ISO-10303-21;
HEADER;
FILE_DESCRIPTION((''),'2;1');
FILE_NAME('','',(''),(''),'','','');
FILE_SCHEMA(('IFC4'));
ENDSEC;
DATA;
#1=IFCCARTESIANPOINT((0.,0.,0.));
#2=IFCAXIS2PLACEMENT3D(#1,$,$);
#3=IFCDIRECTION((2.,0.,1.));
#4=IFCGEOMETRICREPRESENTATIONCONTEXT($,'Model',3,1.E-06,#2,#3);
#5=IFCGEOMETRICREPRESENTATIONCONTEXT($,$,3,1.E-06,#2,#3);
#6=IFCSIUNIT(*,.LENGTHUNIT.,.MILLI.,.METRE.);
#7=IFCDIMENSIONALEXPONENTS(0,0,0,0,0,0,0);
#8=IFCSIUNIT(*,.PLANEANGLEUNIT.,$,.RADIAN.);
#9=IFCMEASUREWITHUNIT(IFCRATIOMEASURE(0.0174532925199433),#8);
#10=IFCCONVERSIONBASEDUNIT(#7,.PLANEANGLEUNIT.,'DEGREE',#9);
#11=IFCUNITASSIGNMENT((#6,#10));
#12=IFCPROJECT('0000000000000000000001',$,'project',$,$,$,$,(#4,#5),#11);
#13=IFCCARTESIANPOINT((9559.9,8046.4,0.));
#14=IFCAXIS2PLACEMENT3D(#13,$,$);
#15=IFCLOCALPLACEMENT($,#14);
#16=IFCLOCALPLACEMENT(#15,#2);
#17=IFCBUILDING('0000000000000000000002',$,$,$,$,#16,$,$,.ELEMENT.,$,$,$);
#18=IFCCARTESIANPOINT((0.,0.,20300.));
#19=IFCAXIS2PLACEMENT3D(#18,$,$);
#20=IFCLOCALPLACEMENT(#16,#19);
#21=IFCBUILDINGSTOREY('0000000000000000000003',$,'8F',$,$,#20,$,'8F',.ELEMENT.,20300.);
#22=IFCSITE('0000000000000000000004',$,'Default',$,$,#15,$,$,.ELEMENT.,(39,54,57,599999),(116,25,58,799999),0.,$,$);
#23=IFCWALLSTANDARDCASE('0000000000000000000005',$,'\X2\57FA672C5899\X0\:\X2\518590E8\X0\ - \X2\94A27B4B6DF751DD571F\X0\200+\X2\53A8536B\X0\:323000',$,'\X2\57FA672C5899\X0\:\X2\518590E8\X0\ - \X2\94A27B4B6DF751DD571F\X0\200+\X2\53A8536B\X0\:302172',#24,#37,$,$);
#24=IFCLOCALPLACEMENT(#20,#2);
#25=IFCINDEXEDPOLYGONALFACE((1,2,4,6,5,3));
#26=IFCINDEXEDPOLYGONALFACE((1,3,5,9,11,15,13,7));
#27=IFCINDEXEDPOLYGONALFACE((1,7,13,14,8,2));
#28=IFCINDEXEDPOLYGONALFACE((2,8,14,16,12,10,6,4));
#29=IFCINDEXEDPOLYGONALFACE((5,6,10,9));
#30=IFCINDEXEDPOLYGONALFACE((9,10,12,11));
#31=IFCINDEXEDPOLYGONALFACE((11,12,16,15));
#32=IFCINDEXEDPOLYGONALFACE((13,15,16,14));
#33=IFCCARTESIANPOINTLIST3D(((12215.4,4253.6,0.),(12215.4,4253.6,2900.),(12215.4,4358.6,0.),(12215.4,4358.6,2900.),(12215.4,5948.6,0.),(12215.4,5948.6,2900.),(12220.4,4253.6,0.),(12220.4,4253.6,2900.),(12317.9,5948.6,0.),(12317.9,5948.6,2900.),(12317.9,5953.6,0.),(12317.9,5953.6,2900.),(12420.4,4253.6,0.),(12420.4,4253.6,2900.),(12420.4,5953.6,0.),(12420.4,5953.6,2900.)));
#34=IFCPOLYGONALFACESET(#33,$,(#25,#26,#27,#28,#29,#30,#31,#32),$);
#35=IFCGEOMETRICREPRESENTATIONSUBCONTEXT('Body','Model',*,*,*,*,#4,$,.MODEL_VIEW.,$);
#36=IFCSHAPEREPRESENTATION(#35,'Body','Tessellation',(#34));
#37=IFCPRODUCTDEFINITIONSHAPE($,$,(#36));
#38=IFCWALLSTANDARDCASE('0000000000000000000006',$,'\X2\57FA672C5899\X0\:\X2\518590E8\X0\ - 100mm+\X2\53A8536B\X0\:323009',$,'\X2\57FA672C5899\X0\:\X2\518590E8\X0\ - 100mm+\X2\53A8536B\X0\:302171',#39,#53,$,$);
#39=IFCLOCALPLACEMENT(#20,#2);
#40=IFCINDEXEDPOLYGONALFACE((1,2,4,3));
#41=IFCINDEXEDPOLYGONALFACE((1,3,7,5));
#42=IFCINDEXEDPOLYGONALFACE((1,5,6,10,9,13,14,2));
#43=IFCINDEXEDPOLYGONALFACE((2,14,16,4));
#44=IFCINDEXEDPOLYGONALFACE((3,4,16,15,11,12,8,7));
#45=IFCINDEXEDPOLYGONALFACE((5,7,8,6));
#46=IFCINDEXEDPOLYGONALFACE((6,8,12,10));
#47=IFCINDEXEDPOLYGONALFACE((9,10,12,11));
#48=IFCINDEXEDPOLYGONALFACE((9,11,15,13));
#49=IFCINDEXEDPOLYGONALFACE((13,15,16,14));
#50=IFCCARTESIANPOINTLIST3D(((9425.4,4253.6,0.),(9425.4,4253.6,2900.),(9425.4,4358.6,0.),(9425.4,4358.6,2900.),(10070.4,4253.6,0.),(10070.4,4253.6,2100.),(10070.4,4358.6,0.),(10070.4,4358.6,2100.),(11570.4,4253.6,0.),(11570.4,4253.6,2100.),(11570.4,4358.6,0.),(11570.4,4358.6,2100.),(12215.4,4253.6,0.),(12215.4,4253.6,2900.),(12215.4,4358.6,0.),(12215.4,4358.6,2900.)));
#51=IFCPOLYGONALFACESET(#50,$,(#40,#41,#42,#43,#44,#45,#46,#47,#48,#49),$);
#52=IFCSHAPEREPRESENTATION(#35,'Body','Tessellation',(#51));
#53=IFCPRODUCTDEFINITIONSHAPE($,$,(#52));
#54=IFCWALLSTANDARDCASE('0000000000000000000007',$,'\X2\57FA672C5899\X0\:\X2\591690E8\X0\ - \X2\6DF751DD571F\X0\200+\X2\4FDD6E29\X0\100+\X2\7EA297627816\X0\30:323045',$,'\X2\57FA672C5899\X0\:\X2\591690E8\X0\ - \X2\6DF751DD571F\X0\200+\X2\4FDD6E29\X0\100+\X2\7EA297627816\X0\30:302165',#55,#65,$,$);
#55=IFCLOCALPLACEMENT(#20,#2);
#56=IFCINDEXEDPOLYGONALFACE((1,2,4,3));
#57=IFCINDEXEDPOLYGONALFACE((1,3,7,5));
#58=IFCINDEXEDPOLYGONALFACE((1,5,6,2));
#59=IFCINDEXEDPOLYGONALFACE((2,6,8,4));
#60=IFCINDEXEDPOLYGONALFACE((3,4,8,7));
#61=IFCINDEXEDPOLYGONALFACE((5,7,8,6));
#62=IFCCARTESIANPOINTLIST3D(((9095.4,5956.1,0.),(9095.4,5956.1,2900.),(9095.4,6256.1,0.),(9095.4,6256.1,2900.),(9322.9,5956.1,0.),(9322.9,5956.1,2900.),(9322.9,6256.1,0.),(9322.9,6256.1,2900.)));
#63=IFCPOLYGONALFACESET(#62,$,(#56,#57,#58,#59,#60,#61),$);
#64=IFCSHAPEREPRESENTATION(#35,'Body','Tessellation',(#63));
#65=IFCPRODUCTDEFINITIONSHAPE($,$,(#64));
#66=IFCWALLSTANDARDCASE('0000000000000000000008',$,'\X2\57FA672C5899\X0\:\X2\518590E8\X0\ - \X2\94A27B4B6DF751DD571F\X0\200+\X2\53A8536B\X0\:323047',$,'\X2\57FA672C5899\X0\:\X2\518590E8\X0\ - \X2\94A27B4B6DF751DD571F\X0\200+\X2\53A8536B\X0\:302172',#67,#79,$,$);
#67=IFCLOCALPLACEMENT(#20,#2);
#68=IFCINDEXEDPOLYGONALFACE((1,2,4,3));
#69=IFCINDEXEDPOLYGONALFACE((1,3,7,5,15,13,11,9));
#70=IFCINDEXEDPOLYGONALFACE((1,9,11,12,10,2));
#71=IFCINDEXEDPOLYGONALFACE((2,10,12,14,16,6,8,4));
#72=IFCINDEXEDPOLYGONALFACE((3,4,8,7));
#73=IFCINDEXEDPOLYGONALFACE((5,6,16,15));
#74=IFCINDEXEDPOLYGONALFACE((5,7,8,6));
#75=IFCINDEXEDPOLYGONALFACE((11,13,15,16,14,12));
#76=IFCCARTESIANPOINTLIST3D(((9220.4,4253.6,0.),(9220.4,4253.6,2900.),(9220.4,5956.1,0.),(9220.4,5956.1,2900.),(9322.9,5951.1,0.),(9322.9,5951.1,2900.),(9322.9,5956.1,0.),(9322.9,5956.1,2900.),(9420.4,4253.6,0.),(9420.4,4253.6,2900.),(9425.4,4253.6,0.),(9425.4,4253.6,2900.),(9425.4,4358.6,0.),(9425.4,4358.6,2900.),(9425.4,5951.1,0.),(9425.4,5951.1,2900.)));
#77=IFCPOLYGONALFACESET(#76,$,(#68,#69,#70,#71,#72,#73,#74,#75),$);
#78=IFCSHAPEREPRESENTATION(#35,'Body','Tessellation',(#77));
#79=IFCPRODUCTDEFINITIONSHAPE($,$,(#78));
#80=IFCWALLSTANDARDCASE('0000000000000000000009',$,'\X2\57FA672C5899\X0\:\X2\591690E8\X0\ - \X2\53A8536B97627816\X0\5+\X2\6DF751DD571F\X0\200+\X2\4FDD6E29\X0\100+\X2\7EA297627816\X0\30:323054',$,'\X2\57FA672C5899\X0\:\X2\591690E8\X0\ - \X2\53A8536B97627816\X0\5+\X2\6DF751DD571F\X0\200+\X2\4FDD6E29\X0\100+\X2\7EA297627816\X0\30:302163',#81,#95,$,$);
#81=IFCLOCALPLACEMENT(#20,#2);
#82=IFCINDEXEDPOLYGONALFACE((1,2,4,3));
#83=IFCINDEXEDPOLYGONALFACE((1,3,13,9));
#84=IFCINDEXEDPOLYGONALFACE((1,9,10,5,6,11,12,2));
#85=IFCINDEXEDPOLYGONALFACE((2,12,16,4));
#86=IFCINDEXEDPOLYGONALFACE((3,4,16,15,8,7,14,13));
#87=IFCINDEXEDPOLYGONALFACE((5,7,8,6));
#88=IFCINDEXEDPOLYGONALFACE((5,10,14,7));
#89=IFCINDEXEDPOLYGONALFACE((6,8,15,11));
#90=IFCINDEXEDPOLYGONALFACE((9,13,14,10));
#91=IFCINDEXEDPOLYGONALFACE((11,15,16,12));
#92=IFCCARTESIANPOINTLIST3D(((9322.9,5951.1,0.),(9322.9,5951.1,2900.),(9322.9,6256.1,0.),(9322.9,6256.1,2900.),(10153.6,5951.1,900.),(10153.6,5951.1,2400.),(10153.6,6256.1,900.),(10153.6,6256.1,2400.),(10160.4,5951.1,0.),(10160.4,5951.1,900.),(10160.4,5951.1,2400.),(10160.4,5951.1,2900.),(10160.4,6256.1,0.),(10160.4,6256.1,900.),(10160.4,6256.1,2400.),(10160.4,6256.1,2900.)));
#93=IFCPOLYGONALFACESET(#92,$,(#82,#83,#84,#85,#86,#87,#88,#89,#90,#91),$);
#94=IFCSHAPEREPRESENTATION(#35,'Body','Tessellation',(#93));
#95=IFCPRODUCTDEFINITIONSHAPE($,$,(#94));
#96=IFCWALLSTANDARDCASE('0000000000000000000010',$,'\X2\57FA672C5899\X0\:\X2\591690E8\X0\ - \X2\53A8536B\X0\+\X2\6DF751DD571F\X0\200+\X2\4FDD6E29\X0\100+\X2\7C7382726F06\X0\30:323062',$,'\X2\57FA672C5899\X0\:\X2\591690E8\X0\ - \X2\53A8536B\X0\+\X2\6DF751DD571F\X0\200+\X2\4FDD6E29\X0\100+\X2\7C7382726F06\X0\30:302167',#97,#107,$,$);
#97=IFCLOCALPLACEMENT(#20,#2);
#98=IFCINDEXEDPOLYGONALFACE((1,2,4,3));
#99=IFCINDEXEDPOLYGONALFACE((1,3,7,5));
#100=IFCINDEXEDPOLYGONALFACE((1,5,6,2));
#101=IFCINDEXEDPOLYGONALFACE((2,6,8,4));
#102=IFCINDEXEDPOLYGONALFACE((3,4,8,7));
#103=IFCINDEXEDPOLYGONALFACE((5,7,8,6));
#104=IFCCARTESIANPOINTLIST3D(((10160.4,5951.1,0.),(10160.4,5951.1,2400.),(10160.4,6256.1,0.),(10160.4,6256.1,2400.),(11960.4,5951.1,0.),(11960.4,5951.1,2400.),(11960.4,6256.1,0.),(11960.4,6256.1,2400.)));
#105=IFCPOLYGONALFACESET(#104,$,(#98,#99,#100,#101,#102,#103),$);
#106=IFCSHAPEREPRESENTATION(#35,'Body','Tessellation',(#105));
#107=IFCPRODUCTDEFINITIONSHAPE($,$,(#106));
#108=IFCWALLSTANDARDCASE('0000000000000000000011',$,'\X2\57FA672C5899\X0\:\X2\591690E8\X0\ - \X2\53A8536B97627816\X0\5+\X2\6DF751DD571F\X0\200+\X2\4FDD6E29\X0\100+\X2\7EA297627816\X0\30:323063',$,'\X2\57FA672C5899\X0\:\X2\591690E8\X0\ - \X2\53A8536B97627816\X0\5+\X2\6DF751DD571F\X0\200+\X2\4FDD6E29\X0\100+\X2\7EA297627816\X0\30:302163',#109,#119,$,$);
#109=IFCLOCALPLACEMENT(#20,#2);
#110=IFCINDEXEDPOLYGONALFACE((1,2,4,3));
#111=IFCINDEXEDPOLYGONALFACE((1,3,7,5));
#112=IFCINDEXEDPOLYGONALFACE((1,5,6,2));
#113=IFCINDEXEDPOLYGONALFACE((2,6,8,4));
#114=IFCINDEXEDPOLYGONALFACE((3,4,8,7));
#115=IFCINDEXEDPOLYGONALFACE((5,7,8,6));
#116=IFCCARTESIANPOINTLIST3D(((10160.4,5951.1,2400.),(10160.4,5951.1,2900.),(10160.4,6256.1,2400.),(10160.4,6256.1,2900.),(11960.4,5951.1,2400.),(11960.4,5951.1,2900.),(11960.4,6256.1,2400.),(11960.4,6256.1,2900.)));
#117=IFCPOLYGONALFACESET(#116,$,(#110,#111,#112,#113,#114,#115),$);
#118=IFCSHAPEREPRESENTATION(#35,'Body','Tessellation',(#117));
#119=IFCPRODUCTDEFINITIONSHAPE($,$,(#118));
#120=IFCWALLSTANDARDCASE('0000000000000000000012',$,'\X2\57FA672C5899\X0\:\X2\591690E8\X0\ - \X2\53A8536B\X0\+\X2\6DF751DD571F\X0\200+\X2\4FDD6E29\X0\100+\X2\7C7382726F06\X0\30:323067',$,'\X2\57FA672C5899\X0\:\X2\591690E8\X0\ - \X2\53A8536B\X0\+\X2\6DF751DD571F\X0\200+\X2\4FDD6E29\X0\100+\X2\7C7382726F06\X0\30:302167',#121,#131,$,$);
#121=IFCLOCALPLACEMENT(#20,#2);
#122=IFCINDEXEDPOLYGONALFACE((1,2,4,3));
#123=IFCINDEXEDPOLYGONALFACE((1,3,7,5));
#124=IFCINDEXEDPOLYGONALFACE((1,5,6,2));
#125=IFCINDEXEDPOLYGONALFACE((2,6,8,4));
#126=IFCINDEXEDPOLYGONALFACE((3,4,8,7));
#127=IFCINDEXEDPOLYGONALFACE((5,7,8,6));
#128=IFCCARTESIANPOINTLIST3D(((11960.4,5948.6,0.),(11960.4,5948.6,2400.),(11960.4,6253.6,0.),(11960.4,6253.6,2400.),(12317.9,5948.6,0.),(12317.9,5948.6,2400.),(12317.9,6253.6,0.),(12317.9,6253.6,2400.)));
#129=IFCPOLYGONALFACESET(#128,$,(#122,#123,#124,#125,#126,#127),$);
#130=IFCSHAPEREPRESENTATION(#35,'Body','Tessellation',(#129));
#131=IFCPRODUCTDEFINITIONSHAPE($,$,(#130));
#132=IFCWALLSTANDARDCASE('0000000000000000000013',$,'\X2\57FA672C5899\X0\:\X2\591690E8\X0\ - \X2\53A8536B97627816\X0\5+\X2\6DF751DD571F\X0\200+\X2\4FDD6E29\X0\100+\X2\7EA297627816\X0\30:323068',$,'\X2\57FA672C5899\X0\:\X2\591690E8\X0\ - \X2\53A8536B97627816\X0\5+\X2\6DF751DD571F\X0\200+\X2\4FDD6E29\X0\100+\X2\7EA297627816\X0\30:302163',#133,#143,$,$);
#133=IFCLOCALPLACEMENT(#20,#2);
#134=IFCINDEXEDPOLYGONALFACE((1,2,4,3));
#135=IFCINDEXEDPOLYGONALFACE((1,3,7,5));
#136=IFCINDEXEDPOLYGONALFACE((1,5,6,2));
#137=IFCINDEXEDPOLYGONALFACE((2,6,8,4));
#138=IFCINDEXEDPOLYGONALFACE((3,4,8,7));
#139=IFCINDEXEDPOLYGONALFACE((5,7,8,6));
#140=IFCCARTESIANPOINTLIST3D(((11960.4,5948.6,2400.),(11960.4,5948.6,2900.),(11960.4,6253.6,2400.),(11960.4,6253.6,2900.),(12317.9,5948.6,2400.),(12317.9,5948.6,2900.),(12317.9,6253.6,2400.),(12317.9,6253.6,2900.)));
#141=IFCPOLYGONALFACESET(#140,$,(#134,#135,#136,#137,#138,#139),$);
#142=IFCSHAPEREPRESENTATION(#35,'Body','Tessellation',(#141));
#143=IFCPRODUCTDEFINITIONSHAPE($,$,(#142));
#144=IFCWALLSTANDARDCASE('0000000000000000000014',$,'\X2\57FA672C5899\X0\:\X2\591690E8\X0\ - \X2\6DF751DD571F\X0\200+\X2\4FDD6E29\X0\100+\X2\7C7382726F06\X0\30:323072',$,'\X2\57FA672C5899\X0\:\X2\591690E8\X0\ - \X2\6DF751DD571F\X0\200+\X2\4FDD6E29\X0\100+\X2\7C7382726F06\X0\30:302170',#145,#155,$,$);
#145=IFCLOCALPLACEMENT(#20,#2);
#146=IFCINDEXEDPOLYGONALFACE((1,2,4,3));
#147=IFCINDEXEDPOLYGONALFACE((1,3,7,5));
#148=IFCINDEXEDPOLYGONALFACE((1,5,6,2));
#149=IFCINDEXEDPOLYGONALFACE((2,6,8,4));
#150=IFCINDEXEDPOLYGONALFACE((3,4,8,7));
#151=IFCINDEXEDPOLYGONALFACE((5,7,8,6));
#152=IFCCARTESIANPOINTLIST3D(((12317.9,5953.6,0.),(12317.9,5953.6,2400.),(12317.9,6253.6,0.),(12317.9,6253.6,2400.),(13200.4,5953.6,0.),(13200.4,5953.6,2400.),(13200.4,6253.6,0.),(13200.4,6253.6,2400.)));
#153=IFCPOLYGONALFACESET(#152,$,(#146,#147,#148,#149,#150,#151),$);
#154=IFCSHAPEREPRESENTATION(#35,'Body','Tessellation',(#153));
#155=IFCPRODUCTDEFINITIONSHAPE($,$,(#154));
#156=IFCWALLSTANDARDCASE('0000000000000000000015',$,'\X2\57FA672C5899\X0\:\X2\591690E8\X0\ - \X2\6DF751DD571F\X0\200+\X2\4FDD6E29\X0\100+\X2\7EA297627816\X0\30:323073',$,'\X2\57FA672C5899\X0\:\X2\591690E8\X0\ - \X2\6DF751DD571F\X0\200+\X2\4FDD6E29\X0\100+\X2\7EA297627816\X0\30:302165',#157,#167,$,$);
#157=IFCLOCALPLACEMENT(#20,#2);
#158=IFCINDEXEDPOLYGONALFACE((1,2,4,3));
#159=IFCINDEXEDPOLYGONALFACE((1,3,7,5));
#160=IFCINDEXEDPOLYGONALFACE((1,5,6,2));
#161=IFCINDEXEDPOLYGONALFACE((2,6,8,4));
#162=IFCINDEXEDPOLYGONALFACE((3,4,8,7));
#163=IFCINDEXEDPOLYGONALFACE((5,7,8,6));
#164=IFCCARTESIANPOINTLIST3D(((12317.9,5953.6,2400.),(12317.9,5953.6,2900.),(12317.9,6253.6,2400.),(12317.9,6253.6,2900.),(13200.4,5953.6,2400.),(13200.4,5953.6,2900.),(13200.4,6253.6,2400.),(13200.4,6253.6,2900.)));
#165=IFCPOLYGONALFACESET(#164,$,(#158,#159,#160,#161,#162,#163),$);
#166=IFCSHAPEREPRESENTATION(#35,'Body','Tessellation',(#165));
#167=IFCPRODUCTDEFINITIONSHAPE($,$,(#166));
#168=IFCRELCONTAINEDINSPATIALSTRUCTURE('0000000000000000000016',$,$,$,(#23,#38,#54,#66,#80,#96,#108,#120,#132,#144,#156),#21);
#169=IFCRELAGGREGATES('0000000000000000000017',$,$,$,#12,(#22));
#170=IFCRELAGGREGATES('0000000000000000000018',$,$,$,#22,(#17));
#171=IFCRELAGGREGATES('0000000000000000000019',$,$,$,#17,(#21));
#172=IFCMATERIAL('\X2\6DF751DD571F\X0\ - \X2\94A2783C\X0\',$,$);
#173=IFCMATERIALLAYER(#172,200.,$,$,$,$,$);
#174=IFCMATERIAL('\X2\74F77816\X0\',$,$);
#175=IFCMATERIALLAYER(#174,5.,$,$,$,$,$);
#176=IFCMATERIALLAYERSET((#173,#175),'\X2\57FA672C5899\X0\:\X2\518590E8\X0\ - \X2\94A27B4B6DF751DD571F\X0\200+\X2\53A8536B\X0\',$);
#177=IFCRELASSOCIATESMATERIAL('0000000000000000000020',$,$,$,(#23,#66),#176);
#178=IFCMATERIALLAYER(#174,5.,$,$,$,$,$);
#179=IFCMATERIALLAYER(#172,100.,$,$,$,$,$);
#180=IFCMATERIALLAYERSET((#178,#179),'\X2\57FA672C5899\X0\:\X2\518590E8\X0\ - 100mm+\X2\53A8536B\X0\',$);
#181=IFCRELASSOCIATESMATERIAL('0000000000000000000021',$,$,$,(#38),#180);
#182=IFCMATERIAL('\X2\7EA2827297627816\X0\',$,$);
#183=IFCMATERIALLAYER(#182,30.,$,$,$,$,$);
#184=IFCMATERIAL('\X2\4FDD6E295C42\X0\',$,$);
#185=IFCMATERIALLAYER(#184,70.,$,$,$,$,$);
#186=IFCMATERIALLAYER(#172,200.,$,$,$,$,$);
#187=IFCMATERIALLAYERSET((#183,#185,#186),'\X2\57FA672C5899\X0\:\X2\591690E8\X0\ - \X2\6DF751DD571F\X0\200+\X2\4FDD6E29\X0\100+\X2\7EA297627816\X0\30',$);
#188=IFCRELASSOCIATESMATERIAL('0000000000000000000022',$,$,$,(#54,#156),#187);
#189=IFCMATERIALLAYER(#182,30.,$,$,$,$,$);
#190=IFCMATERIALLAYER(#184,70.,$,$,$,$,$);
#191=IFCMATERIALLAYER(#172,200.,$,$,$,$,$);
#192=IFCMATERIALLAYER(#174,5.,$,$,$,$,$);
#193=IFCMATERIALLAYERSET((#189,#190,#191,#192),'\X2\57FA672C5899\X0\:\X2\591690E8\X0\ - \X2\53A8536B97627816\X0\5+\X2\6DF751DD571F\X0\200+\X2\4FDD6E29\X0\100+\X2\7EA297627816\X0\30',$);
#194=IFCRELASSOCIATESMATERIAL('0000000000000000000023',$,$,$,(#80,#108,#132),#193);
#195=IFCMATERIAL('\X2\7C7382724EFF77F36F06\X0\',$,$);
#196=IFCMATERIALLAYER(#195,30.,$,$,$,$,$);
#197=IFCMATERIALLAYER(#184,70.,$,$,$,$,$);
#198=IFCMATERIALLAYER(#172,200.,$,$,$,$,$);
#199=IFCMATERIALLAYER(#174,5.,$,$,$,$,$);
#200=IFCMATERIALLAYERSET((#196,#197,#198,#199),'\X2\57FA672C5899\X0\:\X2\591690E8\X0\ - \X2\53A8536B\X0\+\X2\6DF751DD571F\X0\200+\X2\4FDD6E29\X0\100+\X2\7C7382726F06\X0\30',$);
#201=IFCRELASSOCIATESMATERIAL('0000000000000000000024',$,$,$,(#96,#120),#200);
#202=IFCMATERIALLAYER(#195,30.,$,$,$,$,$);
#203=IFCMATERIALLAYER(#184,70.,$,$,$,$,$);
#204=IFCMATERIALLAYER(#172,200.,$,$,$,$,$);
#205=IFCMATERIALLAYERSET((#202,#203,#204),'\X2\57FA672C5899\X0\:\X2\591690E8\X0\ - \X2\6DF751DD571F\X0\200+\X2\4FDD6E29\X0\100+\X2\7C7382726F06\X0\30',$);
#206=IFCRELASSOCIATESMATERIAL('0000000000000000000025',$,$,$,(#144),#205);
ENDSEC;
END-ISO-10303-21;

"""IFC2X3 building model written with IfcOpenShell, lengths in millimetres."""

from ifc_helpers import new_model, entity, si_unit, converted_unit, direction, frame, frame_2d, origin, place, context, subcontext, project, spatial, polyline, rectangle, outline, extrude, material, layer, layer_set, layer_usage, element, save


model = new_model("IFC2X3")

# Units and contexts
model_context = context("Model", 3, precision=1e-06, world=origin(), true_north=direction((2.0, 0.0, 1.0)))
context_of_model = context(None, 3, precision=1e-06, world=origin(), true_north=direction((2.0, 0.0, 1.0)))
body_context = subcontext(model_context, "Body", "Model", "MODEL_VIEW")
ifc_project = project(units=[si_unit("LENGTHUNIT", "METRE", prefix="MILLI"), converted_unit("PLANEANGLEUNIT", "DEGREE", entity("IfcRatioMeasure", 0.0174532925199433), si_unit("PLANEANGLEUNIT", "RADIAN"), dimensions=[0, 0, 0, 0, 0, 0, 0])], contexts=[model_context, context_of_model])

# Site, building, storey
site_placement = place(None, frame((9559.9, 8046.4, 0.0)))
site = spatial("IfcSite", under=ifc_project, at=site_placement, Name="Default", CompositionType="ELEMENT", RefLatitude=(39, 54, 57, 599999), RefLongitude=(116, 25, 58, 799999), RefElevation=0.0)
building_placement = place(site_placement, origin())
building = spatial("IfcBuilding", under=site, at=building_placement, CompositionType="ELEMENT")
storey_placement = place(building_placement, frame((0.0, 0.0, 20300.0)))
storey = spatial("IfcBuildingStorey", under=building, at=storey_placement, Name="8F", LongName="8F", CompositionType="ELEMENT", Elevation=20300.0)

# Shared definitions
ifc_material_1 = material(Name="红色面砖")
ifc_layer_1 = layer(ifc_material_1, 30.0)
ifc_material_2 = material(Name="保温层")
ifc_layer_2 = layer(ifc_material_2, 70.0)
ifc_material_3 = material(Name="混凝土 - 钢砼")
ifc_layer_3 = layer(ifc_material_3, 200.0)
ifc_layer_set_1 = layer_set([ifc_layer_1, ifc_layer_2, ifc_layer_3], Name="基本墙:外部 - 混凝土200+保温100+红面砖30")

# Wall
ifc_layer_4 = layer(ifc_material_3, 200.0)
ifc_material_4 = material(Name="瓷砖")
ifc_layer_5 = layer(ifc_material_4, 5.0)
ifc_layer_set_2 = layer_set([ifc_layer_4, ifc_layer_5], Name="基本墙:内部 - 钢筋混凝土200+厨卫")
ifc_layer_usage_1 = layer_usage(ifc_layer_set_2, "AXIS2", "NEGATIVE", 102.5)
wall_1_placement = place(storey_placement, frame((12317.9, 5953.6, 0.0), z_axis=(0.0, 0.0, 1.0), x_axis=(0.0, -1.0, 0.0)))
element("IfcWallStandardCase", 1, at=wall_1_placement, inside=storey, material=ifc_layer_usage_1, Name="基本墙:内部 - 钢筋混凝土200+厨卫:323000", ObjectType="基本墙:内部 - 钢筋混凝土200+厨卫:302172", context=body_context, shape_type="SweptSolid", body=[
    extrude(outline(polyline([(1700.0, -102.5), (1700.0, -97.5), (1700.0, 102.5), (0.0, 102.5), (0.0, 0.0), (5.0, 0.0), (5.0, -102.5), (1595.0, -102.5), (1700.0, -102.5)])), origin(), (0.0, 0.0, 1.0), 2900.0),
])

# Wall, opening
ifc_layer_6 = layer(ifc_material_4, 5.0)
ifc_layer_7 = layer(ifc_material_3, 100.0)
ifc_layer_set_3 = layer_set([ifc_layer_6, ifc_layer_7], Name="基本墙:内部 - 100mm+厨卫")
ifc_layer_usage_2 = layer_usage(ifc_layer_set_3, "AXIS2", "POSITIVE", -52.5)
wall_2_placement = place(storey_placement, frame((12215.4, 4306.1, 0.0), z_axis=(0.0, 0.0, 1.0), x_axis=(-1.0, 0.0, 0.0)))
wall_2 = element("IfcWallStandardCase", 2, at=wall_2_placement, inside=storey, material=ifc_layer_usage_2, Name="基本墙:内部 - 100mm+厨卫:323009", ObjectType="基本墙:内部 - 100mm+厨卫:302171", context=body_context, shape_type="SweptSolid", body=[
    extrude(rectangle(XDim=2790.0, YDim=105.0, at=frame_2d((1395.0, 0.0), x_axis=(-1.0, 0.0))), origin(), (0.0, 0.0, 1.0), 2900.0),
])
opening_1_placement = place(wall_2_placement, frame((645.0, -52.5, 0.0)))
element("IfcOpeningElement", 3, at=opening_1_placement, cuts=wall_2, ObjectType="Opening", context=body_context, shape_type="SweptSolid", body=[
    extrude(rectangle(XDim=2100.0, YDim=1500.0, at=frame_2d((1050.0, 750.0), x_axis=(1.0, 0.0))), frame((0.0, 0.0, 0.0), z_axis=(0.0, 1.0, 0.0), x_axis=(0.0, 0.0, 1.0)), (0.0, 0.0, 1.0), 105.0),
])

# Walls
ifc_layer_usage_3 = layer_usage(ifc_layer_set_1, "AXIS2", "POSITIVE", -150.0)
wall_3_placement = place(storey_placement, frame((9322.9, 6106.1, 0.0), z_axis=(0.0, 0.0, 1.0), x_axis=(-1.0, 0.0, 0.0)))
element("IfcWallStandardCase", 4, at=wall_3_placement, inside=storey, material=ifc_layer_usage_3, Name="基本墙:外部 - 混凝土200+保温100+红面砖30:323045", ObjectType="基本墙:外部 - 混凝土200+保温100+红面砖30:302165", context=body_context, shape_type="SweptSolid", body=[
    extrude(rectangle(XDim=227.5, YDim=300.0, at=frame_2d((113.8, 0.0), x_axis=(-1.0, 0.0))), origin(), (0.0, 0.0, 1.0), 2900.0),
])
ifc_layer_usage_4 = layer_usage(ifc_layer_set_2, "AXIS2", "POSITIVE", -102.5)
wall_4_placement = place(storey_placement, frame((9322.9, 5956.1, 0.0), z_axis=(0.0, 0.0, 1.0), x_axis=(0.0, -1.0, 0.0)))
element("IfcWallStandardCase", 5, at=wall_4_placement, inside=storey, material=ifc_layer_usage_4, Name="基本墙:内部 - 钢筋混凝土200+厨卫:323047", ObjectType="基本墙:内部 - 钢筋混凝土200+厨卫:302172", context=body_context, shape_type="SweptSolid", body=[
    extrude(outline(polyline([(1702.5, -102.5), (1702.5, 97.5), (1702.5, 102.5), (1597.5, 102.5), (5.0, 102.5), (5.0, 0.0), (0.0, 0.0), (0.0, -102.5), (1702.5, -102.5)])), origin(), (0.0, 0.0, 1.0), 2900.0),
])

# Wall, opening
ifc_layer_8 = layer(ifc_material_1, 30.0)
ifc_layer_9 = layer(ifc_material_2, 70.0)
ifc_layer_10 = layer(ifc_material_3, 200.0)
ifc_layer_11 = layer(ifc_material_4, 5.0)
ifc_layer_set_4 = layer_set([ifc_layer_8, ifc_layer_9, ifc_layer_10, ifc_layer_11], Name="基本墙:外部 - 厨卫面砖5+混凝土200+保温100+红面砖30")
ifc_layer_usage_5 = layer_usage(ifc_layer_set_4, "AXIS2", "POSITIVE", -152.5)
wall_5_placement = place(storey_placement, frame((10160.4, 6103.6, 0.0), z_axis=(0.0, 0.0, 1.0), x_axis=(-1.0, 0.0, 0.0)))
wall_5 = element("IfcWallStandardCase", 6, at=wall_5_placement, inside=storey, material=ifc_layer_usage_5, Name="基本墙:外部 - 厨卫面砖5+混凝土200+保温100+红面砖30:323054", ObjectType="基本墙:外部 - 厨卫面砖5+混凝土200+保温100+红面砖30:302163", context=body_context, shape_type="SweptSolid", body=[
    extrude(rectangle(XDim=837.5, YDim=305.0, at=frame_2d((418.8, 0.0), x_axis=(-1.0, 0.0))), origin(), (0.0, 0.0, 1.0), 2900.0),
])
opening_2_placement = place(wall_5_placement, frame((6.7, 152.5, 900.0)))
element("IfcOpeningElement", 7, at=opening_2_placement, cuts=wall_5, ObjectType="Opening", context=body_context, shape_type="SweptSolid", body=[
    extrude(rectangle(XDim=1500.0, YDim=1800.0, at=frame_2d((750.0, 900.0), x_axis=(1.0, 0.0))), frame((0.0, 0.0, 0.0), z_axis=(0.0, -1.0, 0.0), x_axis=(0.0, 0.0, 1.0)), (0.0, 0.0, 1.0), 305.0),
])

# Walls
ifc_material_5 = material(Name="米色仿石漆")
ifc_layer_12 = layer(ifc_material_5, 30.0)
ifc_layer_13 = layer(ifc_material_2, 70.0)
ifc_layer_14 = layer(ifc_material_3, 200.0)
ifc_layer_15 = layer(ifc_material_4, 5.0)
ifc_layer_set_5 = layer_set([ifc_layer_12, ifc_layer_13, ifc_layer_14, ifc_layer_15], Name="基本墙:外部 - 厨卫+混凝土200+保温100+米色漆30")
ifc_layer_usage_6 = layer_usage(ifc_layer_set_5, "AXIS2", "POSITIVE", -152.5)
wall_6_placement = place(storey_placement, frame((11960.4, 6103.6, 0.0), z_axis=(0.0, 0.0, 1.0), x_axis=(-1.0, 0.0, 0.0)))
element("IfcWallStandardCase", 8, at=wall_6_placement, inside=storey, material=ifc_layer_usage_6, Name="基本墙:外部 - 厨卫+混凝土200+保温100+米色漆30:323062", ObjectType="基本墙:外部 - 厨卫+混凝土200+保温100+米色漆30:302167", context=body_context, shape_type="SweptSolid", body=[
    extrude(rectangle(XDim=1800.0, YDim=305.0, at=frame_2d((900.0, 0.0), x_axis=(-1.0, 0.0))), origin(), (0.0, 0.0, 1.0), 2400.0),
])
ifc_layer_usage_7 = layer_usage(ifc_layer_set_4, "AXIS2", "POSITIVE", -152.5)
wall_7_placement = place(storey_placement, frame((11960.4, 6103.6, 2400.0), z_axis=(0.0, 0.0, 1.0), x_axis=(-1.0, 0.0, 0.0)))
element("IfcWallStandardCase", 9, at=wall_7_placement, inside=storey, material=ifc_layer_usage_7, Name="基本墙:外部 - 厨卫面砖5+混凝土200+保温100+红面砖30:323063", ObjectType="基本墙:外部 - 厨卫面砖5+混凝土200+保温100+红面砖30:302163", context=body_context, shape_type="SweptSolid", body=[
    extrude(rectangle(XDim=1800.0, YDim=305.0, at=frame_2d((900.0, 0.0), x_axis=(-1.0, 0.0))), origin(), (0.0, 0.0, 1.0), 500.0),
])
ifc_layer_usage_8 = layer_usage(ifc_layer_set_5, "AXIS2", "POSITIVE", -152.5)
wall_8_placement = place(storey_placement, frame((12317.9, 6101.1, 0.0), z_axis=(0.0, 0.0, 1.0), x_axis=(-1.0, 0.0, 0.0)))
element("IfcWallStandardCase", 10, at=wall_8_placement, inside=storey, material=ifc_layer_usage_8, Name="基本墙:外部 - 厨卫+混凝土200+保温100+米色漆30:323067", ObjectType="基本墙:外部 - 厨卫+混凝土200+保温100+米色漆30:302167", context=body_context, shape_type="SweptSolid", body=[
    extrude(rectangle(XDim=357.5, YDim=305.0, at=frame_2d((178.8, 0.0), x_axis=(-1.0, 0.0))), origin(), (0.0, 0.0, 1.0), 2400.0),
])
ifc_layer_usage_9 = layer_usage(ifc_layer_set_4, "AXIS2", "POSITIVE", -152.5)
wall_9_placement = place(storey_placement, frame((12317.9, 6101.1, 2400.0), z_axis=(0.0, 0.0, 1.0), x_axis=(-1.0, 0.0, 0.0)))
element("IfcWallStandardCase", 11, at=wall_9_placement, inside=storey, material=ifc_layer_usage_9, Name="基本墙:外部 - 厨卫面砖5+混凝土200+保温100+红面砖30:323068", ObjectType="基本墙:外部 - 厨卫面砖5+混凝土200+保温100+红面砖30:302163", context=body_context, shape_type="SweptSolid", body=[
    extrude(rectangle(XDim=357.5, YDim=305.0, at=frame_2d((178.8, 0.0), x_axis=(-1.0, 0.0))), origin(), (0.0, 0.0, 1.0), 500.0),
])
ifc_layer_16 = layer(ifc_material_5, 30.0)
ifc_layer_17 = layer(ifc_material_2, 70.0)
ifc_layer_18 = layer(ifc_material_3, 200.0)
ifc_layer_set_6 = layer_set([ifc_layer_16, ifc_layer_17, ifc_layer_18], Name="基本墙:外部 - 混凝土200+保温100+米色漆30")
ifc_layer_usage_10 = layer_usage(ifc_layer_set_6, "AXIS2", "POSITIVE", -150.0)
wall_10_placement = place(storey_placement, frame((13200.4, 6103.6, 0.0), z_axis=(0.0, 0.0, 1.0), x_axis=(-1.0, 0.0, 0.0)))
element("IfcWallStandardCase", 12, at=wall_10_placement, inside=storey, material=ifc_layer_usage_10, Name="基本墙:外部 - 混凝土200+保温100+米色漆30:323072", ObjectType="基本墙:外部 - 混凝土200+保温100+米色漆30:302170", context=body_context, shape_type="SweptSolid", body=[
    extrude(rectangle(XDim=882.5, YDim=300.0, at=frame_2d((441.2, 0.0), x_axis=(-1.0, 0.0))), origin(), (0.0, 0.0, 1.0), 2400.0),
])
ifc_layer_usage_11 = layer_usage(ifc_layer_set_1, "AXIS2", "POSITIVE", -150.0)
wall_11_placement = place(storey_placement, frame((13200.4, 6103.6, 2400.0), z_axis=(0.0, 0.0, 1.0), x_axis=(-1.0, 0.0, 0.0)))
element("IfcWallStandardCase", 13, at=wall_11_placement, inside=storey, material=ifc_layer_usage_11, Name="基本墙:外部 - 混凝土200+保温100+红面砖30:323073", ObjectType="基本墙:外部 - 混凝土200+保温100+红面砖30:302165", context=body_context, shape_type="SweptSolid", body=[
    extrude(rectangle(XDim=882.5, YDim=300.0, at=frame_2d((441.2, 0.0), x_axis=(-1.0, 0.0))), origin(), (0.0, 0.0, 1.0), 500.0),
])

save(model, "model.ifc")
